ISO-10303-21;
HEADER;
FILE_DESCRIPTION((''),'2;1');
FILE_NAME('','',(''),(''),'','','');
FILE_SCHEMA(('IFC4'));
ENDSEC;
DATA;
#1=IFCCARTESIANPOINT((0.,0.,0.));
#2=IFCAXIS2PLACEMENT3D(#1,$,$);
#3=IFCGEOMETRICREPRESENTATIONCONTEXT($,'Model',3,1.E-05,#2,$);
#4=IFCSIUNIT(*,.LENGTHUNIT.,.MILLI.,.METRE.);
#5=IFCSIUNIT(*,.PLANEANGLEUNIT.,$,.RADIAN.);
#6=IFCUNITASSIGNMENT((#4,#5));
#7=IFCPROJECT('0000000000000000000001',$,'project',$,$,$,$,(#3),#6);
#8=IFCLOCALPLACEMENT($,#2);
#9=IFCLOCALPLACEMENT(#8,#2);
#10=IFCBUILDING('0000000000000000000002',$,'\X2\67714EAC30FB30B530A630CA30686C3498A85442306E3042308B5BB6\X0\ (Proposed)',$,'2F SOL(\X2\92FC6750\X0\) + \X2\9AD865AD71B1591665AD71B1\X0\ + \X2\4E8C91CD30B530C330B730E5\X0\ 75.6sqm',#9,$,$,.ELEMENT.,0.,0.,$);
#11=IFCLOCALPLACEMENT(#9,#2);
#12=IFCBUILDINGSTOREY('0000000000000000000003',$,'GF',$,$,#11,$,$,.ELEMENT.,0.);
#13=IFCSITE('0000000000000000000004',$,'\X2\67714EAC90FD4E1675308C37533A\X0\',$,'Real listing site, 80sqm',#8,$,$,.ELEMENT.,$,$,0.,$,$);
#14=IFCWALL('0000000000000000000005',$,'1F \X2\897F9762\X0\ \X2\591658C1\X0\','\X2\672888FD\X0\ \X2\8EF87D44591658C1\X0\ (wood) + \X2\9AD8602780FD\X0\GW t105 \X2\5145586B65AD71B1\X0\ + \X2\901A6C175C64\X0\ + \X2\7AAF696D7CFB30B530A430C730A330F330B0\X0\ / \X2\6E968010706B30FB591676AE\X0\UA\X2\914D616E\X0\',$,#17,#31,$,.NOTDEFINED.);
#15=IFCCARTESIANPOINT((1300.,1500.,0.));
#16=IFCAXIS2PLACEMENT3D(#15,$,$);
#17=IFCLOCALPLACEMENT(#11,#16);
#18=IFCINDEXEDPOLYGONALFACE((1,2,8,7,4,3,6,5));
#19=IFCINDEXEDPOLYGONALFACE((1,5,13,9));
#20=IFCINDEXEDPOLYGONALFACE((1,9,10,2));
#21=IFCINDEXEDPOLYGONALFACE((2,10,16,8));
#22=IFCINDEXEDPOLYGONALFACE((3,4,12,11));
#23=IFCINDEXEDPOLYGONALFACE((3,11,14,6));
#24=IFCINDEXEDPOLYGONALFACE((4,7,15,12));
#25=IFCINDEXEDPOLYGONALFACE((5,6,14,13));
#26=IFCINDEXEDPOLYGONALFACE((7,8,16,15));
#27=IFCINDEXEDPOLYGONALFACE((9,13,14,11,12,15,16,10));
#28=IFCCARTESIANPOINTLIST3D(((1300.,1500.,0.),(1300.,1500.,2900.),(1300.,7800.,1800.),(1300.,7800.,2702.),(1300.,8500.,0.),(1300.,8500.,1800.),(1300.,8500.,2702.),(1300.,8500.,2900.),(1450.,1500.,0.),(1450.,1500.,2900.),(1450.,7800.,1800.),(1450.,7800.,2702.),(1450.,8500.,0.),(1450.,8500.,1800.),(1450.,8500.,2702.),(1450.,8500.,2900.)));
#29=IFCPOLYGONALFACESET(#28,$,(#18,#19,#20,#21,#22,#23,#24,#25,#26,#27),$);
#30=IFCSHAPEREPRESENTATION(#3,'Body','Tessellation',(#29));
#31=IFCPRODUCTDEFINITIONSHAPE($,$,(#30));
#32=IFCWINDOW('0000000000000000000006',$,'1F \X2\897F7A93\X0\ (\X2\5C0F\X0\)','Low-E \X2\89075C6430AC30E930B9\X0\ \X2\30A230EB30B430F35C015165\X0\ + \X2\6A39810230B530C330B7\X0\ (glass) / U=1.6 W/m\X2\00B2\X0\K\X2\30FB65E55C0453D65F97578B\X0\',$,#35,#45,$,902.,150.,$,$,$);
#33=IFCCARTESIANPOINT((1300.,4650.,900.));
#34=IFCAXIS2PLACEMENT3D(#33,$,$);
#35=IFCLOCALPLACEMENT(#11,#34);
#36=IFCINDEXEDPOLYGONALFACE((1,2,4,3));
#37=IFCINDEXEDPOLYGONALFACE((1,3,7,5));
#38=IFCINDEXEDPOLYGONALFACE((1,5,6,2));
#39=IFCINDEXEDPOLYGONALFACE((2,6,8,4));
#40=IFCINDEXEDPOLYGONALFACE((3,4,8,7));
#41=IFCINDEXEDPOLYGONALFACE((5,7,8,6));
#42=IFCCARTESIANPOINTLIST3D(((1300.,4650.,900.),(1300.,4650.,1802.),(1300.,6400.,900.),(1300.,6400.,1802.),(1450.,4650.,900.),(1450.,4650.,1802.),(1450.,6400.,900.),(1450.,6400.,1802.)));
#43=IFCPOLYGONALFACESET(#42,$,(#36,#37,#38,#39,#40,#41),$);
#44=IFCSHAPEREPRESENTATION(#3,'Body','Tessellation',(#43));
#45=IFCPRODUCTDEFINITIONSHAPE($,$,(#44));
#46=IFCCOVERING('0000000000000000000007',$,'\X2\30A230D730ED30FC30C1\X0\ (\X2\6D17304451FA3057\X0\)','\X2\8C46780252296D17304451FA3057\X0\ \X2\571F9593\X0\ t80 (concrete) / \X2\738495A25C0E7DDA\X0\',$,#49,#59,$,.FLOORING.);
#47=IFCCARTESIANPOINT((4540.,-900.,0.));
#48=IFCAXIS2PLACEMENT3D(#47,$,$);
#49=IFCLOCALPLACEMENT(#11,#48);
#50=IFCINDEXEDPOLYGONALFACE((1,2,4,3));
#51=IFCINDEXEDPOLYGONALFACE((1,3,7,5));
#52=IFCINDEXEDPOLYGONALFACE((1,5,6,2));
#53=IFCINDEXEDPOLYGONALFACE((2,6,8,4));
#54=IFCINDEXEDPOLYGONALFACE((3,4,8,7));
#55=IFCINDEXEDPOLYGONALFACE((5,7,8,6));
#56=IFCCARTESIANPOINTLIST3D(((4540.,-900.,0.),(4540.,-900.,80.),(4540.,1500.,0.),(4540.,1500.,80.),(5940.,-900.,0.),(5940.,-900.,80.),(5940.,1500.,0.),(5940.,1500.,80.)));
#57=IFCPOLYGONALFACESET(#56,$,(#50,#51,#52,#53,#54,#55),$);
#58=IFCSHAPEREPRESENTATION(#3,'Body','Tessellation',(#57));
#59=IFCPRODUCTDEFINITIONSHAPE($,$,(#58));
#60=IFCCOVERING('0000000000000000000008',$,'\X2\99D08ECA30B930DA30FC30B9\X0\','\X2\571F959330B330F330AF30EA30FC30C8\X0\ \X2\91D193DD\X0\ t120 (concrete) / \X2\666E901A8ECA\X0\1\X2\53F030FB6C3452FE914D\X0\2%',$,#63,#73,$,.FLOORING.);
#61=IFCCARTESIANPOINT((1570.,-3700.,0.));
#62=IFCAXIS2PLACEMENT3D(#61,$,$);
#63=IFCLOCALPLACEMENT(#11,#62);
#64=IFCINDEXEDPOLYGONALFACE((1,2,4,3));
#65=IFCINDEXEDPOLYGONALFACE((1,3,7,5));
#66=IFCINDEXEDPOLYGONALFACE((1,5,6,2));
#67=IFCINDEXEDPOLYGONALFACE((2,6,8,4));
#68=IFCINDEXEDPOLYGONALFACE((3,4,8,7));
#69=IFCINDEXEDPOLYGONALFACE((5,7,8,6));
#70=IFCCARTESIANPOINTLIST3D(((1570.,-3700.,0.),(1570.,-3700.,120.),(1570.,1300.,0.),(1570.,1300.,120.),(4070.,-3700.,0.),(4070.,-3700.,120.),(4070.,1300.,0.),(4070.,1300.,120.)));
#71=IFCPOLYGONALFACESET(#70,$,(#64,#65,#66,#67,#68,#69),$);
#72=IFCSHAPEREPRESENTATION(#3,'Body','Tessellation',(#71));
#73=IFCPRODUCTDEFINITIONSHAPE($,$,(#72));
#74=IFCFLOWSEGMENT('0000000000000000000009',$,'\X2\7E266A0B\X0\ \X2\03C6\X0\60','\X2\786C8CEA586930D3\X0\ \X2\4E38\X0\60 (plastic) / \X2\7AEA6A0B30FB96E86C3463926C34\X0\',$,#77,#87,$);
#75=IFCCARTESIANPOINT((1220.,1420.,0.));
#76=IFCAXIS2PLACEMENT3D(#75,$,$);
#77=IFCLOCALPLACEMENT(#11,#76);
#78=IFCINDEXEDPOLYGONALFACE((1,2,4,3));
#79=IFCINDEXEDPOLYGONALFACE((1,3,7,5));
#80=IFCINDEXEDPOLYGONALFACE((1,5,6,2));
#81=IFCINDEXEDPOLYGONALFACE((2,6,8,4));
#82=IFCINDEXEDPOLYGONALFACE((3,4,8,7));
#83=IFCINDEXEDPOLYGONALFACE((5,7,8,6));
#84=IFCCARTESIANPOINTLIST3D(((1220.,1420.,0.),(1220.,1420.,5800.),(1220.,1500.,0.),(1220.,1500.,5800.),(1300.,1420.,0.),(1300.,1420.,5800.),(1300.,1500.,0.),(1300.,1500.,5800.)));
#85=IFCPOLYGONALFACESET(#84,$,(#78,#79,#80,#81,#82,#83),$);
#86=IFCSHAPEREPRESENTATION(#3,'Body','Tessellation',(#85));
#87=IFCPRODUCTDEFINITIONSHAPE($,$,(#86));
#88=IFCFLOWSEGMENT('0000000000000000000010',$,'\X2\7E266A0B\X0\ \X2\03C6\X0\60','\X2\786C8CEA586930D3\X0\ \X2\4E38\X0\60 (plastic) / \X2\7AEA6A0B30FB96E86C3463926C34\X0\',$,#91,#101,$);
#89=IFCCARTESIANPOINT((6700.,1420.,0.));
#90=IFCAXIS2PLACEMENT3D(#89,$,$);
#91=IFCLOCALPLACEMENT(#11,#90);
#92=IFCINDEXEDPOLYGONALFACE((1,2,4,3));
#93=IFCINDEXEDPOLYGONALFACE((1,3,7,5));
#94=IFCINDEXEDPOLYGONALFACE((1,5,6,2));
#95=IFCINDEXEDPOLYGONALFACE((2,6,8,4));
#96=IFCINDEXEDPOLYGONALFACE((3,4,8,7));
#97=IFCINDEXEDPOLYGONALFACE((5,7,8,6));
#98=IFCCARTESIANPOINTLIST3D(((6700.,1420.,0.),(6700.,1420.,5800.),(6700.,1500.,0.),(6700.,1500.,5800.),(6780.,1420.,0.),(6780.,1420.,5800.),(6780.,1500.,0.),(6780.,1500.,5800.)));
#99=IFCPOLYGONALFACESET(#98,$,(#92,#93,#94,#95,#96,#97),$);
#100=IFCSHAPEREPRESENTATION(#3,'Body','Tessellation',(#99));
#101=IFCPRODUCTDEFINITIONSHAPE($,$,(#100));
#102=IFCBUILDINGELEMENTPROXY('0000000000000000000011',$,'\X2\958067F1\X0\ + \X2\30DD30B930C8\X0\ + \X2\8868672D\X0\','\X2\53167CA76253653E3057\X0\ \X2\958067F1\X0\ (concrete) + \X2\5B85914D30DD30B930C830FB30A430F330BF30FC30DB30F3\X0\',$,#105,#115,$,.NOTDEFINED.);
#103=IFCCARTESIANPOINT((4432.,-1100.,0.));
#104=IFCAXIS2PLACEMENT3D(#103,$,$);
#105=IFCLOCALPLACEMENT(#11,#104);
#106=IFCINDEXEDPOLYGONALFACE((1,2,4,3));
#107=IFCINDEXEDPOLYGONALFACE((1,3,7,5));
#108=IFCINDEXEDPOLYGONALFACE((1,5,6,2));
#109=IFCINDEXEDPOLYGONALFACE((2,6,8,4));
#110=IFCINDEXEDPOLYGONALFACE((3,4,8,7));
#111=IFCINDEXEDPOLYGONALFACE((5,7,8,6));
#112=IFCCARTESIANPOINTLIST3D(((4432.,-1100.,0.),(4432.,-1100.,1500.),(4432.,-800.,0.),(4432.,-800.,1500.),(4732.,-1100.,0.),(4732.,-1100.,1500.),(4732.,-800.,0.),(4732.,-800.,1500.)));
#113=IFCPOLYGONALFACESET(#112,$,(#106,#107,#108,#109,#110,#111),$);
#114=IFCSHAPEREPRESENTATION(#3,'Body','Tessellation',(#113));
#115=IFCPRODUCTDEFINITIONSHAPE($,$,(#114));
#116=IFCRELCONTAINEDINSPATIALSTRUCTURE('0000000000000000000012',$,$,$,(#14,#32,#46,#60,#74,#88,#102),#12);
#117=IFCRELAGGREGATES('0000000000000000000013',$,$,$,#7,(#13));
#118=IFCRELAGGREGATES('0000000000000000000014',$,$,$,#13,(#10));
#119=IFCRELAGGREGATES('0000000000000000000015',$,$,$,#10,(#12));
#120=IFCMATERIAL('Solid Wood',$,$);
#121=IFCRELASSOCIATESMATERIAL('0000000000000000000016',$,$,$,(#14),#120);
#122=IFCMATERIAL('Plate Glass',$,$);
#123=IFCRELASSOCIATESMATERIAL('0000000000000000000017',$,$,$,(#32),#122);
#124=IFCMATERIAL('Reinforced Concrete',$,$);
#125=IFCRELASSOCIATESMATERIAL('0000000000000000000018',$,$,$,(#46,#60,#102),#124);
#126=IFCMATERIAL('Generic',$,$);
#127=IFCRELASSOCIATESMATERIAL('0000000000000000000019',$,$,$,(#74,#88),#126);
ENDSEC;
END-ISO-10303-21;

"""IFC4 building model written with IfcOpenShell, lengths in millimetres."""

from ifc_helpers import new_model, si_unit, frame, frame_2d, origin, place, context, project, spatial, rectangle, extrude, material, element, fill, save


model = new_model("IFC4")

# Units and contexts
model_context = context("Model", 3, precision=1e-05, world=origin())
ifc_project = project(units=[si_unit("LENGTHUNIT", "METRE", prefix="MILLI"), si_unit("PLANEANGLEUNIT", "RADIAN")], contexts=[model_context])

# Site, building, storey
site_placement = place(None, origin())
site = spatial("IfcSite", under=ifc_project, at=site_placement, Name="東京都世田谷区", ObjectType="Real listing site, 80sqm", CompositionType="ELEMENT", RefElevation=0.0)
building_placement = place(site_placement, origin())
building = spatial("IfcBuilding", under=site, at=building_placement, Name="東京・サウナと水風呂のある家 (Proposed)", ObjectType="2F SOL(鋼材) + 高断熱外断熱 + 二重サッシュ 75.6sqm", CompositionType="ELEMENT", ElevationOfRefHeight=0.0, ElevationOfTerrain=0.0)
storey_placement = place(building_placement, origin())
storey = spatial("IfcBuildingStorey", under=building, at=storey_placement, Name="GF", CompositionType="ELEMENT", Elevation=0.0)

# Shared definitions
ifc_material_1 = material(Name="Solid Wood")

# Shared definitions
ifc_material_2 = material(Name="Reinforced Concrete")

# Shared definitions
ifc_material_3 = material(Name="Plate Glass")

# Wall, opening, window
wall_1_placement = place(storey_placement, frame((1300.0, 1500.0, 0.0)))
wall_1 = element("IfcWall", 1, at=wall_1_placement, inside=storey, material=ifc_material_1, Name="1F 西面 外壁", Description="木製 軸組外壁 (wood) + 高性能GW t105 充填断熱 + 通気層 + 窯業系サイディング / 準耐火・外皮UA配慮", PredefinedType="NOTDEFINED", context=model_context, shape_type="SweptSolid", body=[
    extrude(rectangle(XDim=150.0, YDim=7000.0, at=frame_2d((75.0, 3500.0))), frame((1300.0, 1500.0, 0.0)), (0.0, 0.0, 1.0), 2900.0),
])
opening_1_placement = place(storey_placement, frame((1300.0, 4650.0, 900.0)))
opening_1 = element("IfcOpeningElement", 2, at=opening_1_placement, cuts=wall_1, PredefinedType="NOTDEFINED", context=model_context, shape_type="SweptSolid", body=[
    extrude(rectangle(XDim=150.0, YDim=1750.0, at=frame_2d((75.0, 875.0))), frame((1300.0, 4650.0, 900.0)), (0.0, 0.0, 1.0), 902.0),
])
window_1_placement = place(storey_placement, frame((1300.0, 4650.0, 900.0)))
window_1 = element("IfcWindow", 3, at=window_1_placement, inside=storey, material=ifc_material_3, Name="1F 西窓 (小)", Description="Low-E 複層ガラス アルゴン封入 + 樹脂サッシ (glass) / U=1.6 W/m²K・日射取得型", OverallHeight=902.0, OverallWidth=150.0, context=model_context, shape_type="SweptSolid", body=[
    extrude(rectangle(XDim=150.0, YDim=1750.0, at=frame_2d((75.0, 875.0))), frame((1300.0, 4650.0, 900.0)), (0.0, 0.0, 1.0), 902.0),
])
fill(opening_1, window_1)

# Coverings
covering_1_placement = place(storey_placement, frame((4540.0, -900.0, 0.0)))
element("IfcCovering", 4, at=covering_1_placement, inside=storey, material=ifc_material_2, Name="アプローチ (洗い出し)", Description="豆砂利洗い出し 土間 t80 (concrete) / 玄関導線", PredefinedType="FLOORING", context=model_context, shape_type="SweptSolid", body=[
    extrude(rectangle(XDim=1400.0, YDim=2400.0, at=frame_2d((700.0, 1200.0))), frame((4540.0, -900.0, 0.0)), (0.0, 0.0, 1.0), 80.0),
])
covering_2_placement = place(storey_placement, frame((1570.0, -3700.0, 0.0)))
element("IfcCovering", 5, at=covering_2_placement, inside=storey, material=ifc_material_2, Name="駐車スペース", Description="土間コンクリート 金鏝 t120 (concrete) / 普通車1台・水勾配2%", PredefinedType="FLOORING", context=model_context, shape_type="SweptSolid", body=[
    extrude(rectangle(XDim=2500.0, YDim=5000.0, at=frame_2d((1250.0, 2500.0))), frame((1570.0, -3700.0, 0.0)), (0.0, 0.0, 1.0), 120.0),
])

# Flow segments
ifc_material_4 = material(Name="Generic")
flow_segment_1_placement = place(storey_placement, frame((1220.0, 1420.0, 0.0)))
element("IfcFlowSegment", 6, at=flow_segment_1_placement, inside=storey, material=ifc_material_4, Name="縦樋 φ60", Description="硬質塩ビ 丸60 (plastic) / 竪樋・雨水排水", context=model_context, shape_type="SweptSolid", body=[
    extrude(rectangle(XDim=80.0, YDim=80.0, at=frame_2d((40.0, 40.0))), frame((1220.0, 1420.0, 0.0)), (0.0, 0.0, 1.0), 5800.0),
])
flow_segment_2_placement = place(storey_placement, frame((6700.0, 1420.0, 0.0)))
element("IfcFlowSegment", 7, at=flow_segment_2_placement, inside=storey, material=ifc_material_4, Name="縦樋 φ60", Description="硬質塩ビ 丸60 (plastic) / 竪樋・雨水排水", context=model_context, shape_type="SweptSolid", body=[
    extrude(rectangle(XDim=80.0, YDim=80.0, at=frame_2d((40.0, 40.0))), frame((6700.0, 1420.0, 0.0)), (0.0, 0.0, 1.0), 5800.0),
])

# Building element proxy
proxy_placement = place(storey_placement, frame((4432.0, -1100.0, 0.0)))
element("IfcBuildingElementProxy", 8, at=proxy_placement, inside=storey, material=ifc_material_2, Name="門柱 + ポスト + 表札", Description="化粧打放し 門柱 (concrete) + 宅配ポスト・インターホン", PredefinedType="NOTDEFINED", context=model_context, shape_type="SweptSolid", body=[
    extrude(rectangle(XDim=300.0, YDim=300.0, at=frame_2d((150.0, 150.0))), frame((4432.0, -1100.0, 0.0)), (0.0, 0.0, 1.0), 1500.0),
])

save(model, "model.ifc")
